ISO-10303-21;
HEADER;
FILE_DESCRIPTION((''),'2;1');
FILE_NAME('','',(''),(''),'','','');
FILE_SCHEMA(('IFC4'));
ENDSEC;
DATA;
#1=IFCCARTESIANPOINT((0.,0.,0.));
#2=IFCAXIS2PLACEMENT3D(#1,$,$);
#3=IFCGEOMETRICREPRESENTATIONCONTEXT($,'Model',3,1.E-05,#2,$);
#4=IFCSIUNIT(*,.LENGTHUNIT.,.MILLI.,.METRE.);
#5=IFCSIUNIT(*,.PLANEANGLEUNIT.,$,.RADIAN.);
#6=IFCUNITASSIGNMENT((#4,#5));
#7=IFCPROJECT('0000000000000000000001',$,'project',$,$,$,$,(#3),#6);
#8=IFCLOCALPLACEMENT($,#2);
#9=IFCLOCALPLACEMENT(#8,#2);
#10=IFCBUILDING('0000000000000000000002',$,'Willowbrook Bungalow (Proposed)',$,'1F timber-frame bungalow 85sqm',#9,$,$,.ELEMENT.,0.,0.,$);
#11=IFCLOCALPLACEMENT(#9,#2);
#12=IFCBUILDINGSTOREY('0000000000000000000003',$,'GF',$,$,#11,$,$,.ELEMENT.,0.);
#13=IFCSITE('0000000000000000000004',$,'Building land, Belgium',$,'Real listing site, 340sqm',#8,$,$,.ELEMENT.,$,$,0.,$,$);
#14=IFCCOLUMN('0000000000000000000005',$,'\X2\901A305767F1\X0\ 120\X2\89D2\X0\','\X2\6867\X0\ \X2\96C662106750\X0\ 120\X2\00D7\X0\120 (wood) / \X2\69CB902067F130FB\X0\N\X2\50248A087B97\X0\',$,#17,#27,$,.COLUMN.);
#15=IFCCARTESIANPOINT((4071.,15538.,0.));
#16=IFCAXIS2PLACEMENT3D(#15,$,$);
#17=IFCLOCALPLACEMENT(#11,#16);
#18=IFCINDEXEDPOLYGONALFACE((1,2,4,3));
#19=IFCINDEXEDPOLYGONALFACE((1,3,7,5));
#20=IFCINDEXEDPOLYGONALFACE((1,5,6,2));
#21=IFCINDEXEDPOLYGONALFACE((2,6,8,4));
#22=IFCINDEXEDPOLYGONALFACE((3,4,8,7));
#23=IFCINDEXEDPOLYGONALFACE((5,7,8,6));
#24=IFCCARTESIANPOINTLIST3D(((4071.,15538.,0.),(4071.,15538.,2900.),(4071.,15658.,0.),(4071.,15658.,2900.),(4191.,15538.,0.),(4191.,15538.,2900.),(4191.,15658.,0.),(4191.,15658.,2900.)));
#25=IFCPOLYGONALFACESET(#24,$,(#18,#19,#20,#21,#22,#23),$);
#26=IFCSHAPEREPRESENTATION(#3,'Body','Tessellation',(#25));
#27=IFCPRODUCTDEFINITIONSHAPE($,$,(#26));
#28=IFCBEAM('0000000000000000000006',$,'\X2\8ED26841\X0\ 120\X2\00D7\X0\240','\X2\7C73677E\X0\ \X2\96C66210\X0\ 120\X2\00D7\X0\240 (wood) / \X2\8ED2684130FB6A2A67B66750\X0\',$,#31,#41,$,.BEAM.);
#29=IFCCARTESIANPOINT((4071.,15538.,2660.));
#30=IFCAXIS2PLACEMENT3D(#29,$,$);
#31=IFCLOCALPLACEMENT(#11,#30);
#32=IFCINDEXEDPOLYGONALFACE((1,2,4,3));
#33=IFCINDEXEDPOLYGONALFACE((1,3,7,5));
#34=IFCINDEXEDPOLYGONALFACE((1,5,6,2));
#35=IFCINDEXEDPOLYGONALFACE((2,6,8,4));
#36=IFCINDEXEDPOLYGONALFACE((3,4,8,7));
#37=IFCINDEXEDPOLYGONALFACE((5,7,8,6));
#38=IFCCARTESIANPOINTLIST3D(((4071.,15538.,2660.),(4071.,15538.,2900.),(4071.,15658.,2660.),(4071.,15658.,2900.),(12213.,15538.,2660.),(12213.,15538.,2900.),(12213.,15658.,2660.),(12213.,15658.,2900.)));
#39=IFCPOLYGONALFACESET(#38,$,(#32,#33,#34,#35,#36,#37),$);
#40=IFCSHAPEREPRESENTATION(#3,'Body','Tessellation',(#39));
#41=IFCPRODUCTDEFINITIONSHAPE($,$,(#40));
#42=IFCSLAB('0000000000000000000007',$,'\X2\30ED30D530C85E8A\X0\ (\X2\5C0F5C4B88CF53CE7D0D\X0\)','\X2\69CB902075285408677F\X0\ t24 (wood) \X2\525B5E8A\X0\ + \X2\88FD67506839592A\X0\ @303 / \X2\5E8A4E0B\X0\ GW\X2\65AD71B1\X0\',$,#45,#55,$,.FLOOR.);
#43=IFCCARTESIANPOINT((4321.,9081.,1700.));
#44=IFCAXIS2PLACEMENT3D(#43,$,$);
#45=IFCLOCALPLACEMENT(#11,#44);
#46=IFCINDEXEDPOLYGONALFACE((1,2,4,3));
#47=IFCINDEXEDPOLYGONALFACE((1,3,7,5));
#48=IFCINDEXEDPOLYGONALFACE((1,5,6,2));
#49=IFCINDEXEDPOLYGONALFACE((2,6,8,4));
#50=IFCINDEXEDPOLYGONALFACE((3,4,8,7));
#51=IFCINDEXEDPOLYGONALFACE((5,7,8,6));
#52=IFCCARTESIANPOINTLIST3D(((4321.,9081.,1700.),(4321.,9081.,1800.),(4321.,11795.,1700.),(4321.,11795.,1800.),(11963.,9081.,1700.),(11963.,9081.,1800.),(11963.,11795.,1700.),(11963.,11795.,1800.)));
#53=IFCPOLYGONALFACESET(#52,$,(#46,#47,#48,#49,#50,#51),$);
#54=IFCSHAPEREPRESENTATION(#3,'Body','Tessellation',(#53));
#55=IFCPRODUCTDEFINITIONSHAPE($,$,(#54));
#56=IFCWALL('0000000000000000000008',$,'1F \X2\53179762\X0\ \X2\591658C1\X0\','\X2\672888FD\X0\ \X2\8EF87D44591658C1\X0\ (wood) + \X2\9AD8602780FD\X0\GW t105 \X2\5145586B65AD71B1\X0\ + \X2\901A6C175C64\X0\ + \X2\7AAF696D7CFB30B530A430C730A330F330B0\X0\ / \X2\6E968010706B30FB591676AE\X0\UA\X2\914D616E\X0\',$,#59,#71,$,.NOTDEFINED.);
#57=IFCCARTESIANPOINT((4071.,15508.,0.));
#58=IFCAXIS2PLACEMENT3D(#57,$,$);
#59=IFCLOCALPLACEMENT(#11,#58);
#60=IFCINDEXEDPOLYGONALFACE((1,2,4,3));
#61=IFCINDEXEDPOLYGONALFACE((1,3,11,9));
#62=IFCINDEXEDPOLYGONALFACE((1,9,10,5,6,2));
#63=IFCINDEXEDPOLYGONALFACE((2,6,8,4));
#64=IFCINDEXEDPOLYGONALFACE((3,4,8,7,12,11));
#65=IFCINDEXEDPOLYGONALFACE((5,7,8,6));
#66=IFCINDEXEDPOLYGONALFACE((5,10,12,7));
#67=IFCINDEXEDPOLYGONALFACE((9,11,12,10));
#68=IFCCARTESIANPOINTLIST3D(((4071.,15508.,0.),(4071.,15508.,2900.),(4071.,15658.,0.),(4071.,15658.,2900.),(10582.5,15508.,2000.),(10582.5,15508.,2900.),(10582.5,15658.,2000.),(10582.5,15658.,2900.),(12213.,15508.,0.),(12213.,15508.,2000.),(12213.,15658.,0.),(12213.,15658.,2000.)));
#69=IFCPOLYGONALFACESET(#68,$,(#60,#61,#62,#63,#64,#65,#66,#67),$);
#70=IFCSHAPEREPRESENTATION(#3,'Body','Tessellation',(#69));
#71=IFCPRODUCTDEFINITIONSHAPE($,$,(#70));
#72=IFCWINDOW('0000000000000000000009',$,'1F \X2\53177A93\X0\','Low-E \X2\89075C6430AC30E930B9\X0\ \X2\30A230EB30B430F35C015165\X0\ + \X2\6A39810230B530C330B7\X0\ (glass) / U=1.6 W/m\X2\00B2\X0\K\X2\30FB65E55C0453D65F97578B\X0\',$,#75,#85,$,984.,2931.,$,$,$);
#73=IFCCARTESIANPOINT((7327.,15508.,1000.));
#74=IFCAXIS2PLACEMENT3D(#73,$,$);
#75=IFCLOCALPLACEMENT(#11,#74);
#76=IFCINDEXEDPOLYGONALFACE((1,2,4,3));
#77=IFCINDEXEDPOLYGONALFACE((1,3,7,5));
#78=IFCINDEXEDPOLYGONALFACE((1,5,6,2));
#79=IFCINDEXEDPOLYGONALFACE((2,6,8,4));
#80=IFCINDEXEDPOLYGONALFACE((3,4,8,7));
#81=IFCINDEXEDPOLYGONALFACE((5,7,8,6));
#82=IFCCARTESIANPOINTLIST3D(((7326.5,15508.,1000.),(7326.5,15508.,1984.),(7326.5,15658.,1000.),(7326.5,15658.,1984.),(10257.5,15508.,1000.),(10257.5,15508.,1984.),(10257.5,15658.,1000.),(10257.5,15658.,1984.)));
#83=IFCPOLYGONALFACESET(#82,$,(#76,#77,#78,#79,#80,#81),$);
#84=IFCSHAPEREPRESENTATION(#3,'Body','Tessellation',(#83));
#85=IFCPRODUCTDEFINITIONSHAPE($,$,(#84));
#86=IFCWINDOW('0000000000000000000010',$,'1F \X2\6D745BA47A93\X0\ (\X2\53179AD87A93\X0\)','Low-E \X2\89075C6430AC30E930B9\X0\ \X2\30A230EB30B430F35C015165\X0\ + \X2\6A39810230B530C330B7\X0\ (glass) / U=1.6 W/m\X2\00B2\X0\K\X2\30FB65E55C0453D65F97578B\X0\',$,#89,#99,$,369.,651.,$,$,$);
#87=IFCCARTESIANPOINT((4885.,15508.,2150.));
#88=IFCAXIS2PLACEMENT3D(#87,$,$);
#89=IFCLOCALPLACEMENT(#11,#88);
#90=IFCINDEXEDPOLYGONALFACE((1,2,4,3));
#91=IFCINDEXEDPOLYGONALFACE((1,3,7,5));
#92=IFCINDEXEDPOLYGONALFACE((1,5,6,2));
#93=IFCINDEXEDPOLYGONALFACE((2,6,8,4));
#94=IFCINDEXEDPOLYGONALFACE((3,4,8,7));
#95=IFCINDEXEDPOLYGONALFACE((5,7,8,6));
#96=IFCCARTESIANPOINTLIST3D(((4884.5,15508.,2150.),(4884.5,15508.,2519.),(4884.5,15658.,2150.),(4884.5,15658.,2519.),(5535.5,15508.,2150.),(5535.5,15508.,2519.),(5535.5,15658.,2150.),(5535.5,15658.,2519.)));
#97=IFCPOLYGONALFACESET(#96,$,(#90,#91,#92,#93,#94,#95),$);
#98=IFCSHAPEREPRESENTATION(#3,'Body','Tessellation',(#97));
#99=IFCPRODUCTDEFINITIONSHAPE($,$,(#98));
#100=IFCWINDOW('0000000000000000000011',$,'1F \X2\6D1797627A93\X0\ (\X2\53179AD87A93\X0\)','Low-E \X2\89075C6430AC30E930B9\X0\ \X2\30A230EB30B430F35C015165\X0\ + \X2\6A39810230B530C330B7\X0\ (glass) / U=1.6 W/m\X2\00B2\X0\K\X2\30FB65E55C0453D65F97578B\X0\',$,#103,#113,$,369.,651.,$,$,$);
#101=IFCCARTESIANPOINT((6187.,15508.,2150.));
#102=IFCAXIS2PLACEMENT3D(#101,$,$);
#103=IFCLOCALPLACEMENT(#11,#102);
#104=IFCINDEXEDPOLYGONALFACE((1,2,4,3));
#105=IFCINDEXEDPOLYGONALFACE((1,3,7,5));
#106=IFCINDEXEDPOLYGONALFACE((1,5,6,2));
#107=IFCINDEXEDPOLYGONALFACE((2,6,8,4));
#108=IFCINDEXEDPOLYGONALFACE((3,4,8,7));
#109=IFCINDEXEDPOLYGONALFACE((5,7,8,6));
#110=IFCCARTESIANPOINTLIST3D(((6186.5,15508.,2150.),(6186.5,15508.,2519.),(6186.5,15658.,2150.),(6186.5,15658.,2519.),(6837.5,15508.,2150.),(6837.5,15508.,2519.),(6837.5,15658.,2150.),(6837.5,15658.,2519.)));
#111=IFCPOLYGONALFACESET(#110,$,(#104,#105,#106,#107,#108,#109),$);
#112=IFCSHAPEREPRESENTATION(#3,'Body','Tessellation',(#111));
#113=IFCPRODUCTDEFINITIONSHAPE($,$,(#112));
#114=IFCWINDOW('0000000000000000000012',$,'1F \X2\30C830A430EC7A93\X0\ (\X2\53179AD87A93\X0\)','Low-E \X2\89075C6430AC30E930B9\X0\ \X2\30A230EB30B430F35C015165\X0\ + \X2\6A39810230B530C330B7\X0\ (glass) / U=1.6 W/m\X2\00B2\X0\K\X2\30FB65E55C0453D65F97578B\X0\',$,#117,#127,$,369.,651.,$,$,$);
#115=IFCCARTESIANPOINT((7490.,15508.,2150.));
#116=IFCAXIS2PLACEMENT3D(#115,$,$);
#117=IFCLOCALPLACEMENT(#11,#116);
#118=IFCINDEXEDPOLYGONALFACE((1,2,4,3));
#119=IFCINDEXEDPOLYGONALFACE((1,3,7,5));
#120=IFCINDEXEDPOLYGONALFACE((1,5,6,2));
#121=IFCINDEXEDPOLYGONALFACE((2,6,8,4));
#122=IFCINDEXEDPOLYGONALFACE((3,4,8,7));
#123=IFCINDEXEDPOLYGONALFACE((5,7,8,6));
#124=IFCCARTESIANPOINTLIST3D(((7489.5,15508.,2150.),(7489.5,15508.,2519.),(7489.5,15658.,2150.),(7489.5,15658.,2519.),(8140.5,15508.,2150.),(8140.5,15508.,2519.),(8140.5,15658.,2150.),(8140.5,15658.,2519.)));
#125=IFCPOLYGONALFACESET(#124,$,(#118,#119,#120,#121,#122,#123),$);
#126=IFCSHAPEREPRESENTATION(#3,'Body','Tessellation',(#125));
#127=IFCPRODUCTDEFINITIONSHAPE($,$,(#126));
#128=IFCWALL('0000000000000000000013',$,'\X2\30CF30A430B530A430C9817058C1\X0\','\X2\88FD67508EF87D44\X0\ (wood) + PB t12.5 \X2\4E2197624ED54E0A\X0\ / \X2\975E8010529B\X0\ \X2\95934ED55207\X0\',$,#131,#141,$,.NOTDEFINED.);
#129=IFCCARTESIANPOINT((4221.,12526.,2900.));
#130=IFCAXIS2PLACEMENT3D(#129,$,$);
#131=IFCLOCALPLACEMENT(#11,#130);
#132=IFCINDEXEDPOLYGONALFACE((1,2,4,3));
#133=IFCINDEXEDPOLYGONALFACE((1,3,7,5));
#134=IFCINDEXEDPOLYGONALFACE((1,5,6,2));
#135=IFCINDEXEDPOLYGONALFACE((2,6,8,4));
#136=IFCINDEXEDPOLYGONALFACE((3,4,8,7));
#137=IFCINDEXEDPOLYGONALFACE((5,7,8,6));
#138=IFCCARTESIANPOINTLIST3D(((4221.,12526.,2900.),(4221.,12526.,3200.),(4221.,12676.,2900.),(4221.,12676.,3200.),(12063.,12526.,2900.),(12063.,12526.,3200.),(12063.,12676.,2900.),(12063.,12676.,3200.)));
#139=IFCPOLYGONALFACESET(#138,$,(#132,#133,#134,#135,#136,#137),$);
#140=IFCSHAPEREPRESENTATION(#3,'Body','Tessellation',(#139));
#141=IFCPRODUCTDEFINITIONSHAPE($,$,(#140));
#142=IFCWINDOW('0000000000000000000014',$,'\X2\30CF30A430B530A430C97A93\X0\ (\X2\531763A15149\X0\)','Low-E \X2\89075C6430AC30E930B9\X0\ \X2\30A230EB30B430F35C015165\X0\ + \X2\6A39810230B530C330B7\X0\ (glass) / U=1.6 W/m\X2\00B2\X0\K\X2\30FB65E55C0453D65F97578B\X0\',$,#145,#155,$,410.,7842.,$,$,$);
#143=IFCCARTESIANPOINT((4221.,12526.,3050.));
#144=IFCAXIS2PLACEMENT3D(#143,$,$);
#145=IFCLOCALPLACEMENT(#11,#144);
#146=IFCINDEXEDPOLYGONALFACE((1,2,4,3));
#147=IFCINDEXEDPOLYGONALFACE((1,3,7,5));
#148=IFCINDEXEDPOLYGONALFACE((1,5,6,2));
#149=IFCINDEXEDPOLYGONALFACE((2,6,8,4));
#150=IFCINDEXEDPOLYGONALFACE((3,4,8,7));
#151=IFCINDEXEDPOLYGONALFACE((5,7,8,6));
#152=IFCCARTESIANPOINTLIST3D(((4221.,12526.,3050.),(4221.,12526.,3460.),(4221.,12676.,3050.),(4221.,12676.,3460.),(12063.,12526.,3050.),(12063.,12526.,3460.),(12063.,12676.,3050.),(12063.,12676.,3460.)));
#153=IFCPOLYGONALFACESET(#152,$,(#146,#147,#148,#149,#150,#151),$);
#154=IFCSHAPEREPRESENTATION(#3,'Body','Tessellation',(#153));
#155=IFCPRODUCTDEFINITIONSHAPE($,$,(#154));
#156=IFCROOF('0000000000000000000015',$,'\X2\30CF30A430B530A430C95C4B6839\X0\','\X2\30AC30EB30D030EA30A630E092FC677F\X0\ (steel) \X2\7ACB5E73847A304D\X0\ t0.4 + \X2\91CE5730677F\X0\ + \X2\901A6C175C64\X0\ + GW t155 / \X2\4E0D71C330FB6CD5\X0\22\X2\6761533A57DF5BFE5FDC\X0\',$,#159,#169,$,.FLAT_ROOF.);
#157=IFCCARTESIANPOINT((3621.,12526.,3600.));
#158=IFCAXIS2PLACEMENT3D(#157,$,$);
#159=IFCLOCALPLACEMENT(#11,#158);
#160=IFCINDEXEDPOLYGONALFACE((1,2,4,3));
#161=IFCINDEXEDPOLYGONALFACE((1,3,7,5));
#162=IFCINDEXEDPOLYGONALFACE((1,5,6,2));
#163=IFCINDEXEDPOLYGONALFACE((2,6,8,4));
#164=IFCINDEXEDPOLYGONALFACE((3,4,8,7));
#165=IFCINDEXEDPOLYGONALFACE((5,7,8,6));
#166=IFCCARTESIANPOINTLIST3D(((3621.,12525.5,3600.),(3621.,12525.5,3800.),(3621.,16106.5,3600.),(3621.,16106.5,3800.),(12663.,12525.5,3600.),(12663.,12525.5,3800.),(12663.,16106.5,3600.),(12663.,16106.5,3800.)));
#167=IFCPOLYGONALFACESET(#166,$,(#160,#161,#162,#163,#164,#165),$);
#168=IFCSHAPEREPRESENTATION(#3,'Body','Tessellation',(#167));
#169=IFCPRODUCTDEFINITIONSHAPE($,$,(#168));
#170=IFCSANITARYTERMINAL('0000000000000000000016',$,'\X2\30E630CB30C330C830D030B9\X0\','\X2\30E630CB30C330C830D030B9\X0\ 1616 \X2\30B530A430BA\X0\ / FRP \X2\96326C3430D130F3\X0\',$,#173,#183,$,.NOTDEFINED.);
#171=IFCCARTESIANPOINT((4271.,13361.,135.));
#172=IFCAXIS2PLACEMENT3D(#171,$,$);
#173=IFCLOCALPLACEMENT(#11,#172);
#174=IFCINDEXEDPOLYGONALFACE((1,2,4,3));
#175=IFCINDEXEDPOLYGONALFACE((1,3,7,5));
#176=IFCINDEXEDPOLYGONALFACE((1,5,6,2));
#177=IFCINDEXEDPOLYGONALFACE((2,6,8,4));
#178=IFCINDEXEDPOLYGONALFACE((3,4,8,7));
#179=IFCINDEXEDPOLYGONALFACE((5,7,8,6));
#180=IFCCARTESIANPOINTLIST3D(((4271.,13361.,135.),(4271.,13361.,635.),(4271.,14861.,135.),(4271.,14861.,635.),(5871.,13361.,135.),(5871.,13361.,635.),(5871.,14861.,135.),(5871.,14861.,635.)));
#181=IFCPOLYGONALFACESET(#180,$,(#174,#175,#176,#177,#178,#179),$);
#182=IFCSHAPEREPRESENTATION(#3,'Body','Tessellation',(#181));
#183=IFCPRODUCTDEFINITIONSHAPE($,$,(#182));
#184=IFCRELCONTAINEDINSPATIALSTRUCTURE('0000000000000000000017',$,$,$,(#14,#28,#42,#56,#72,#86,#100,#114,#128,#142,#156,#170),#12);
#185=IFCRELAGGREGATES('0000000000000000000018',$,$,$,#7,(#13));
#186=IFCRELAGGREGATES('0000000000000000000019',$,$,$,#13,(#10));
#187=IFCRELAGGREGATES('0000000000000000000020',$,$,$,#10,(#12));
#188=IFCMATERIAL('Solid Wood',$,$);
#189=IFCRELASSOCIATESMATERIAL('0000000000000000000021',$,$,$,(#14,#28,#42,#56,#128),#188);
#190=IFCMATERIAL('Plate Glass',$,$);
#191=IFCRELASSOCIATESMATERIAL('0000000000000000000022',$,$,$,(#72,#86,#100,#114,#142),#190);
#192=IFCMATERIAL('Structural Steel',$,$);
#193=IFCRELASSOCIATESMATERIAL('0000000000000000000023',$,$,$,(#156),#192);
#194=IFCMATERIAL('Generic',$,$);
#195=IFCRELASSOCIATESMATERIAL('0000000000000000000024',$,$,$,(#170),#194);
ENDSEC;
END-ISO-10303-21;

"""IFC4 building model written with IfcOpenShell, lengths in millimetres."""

from ifc_helpers import new_model, si_unit, frame, frame_2d, origin, place, context, project, spatial, rectangle, extrude, material, element, fill, save


model = new_model("IFC4")

# Units and contexts
model_context = context("Model", 3, precision=1e-05, world=origin())
ifc_project = project(units=[si_unit("LENGTHUNIT", "METRE", prefix="MILLI"), si_unit("PLANEANGLEUNIT", "RADIAN")], contexts=[model_context])

# Site, building, storey
site_placement = place(None, origin())
site = spatial("IfcSite", under=ifc_project, at=site_placement, Name="Building land, Belgium", ObjectType="Real listing site, 340sqm", CompositionType="ELEMENT", RefElevation=0.0)
building_placement = place(site_placement, origin())
building = spatial("IfcBuilding", under=site, at=building_placement, Name="Willowbrook Bungalow (Proposed)", ObjectType="1F timber-frame bungalow 85sqm", CompositionType="ELEMENT", ElevationOfRefHeight=0.0, ElevationOfTerrain=0.0)
storey_placement = place(building_placement, origin())
storey = spatial("IfcBuildingStorey", under=building, at=storey_placement, Name="GF", CompositionType="ELEMENT", Elevation=0.0)

# Column
ifc_material_1 = material(Name="Solid Wood")
column_1_placement = place(storey_placement, frame((4071.0, 15538.0, 0.0)))
element("IfcColumn", 1, at=column_1_placement, inside=storey, material=ifc_material_1, Name="通し柱 120角", Description="桧 集成材 120×120 (wood) / 構造柱・N値計算", PredefinedType="COLUMN", context=model_context, shape_type="SweptSolid", body=[
    extrude(rectangle(XDim=120.0, YDim=120.0, at=frame_2d((60.0, 60.0))), frame((4071.0, 15538.0, 0.0)), (0.0, 0.0, 1.0), 2900.0),
])

# Beam
beam_1_placement = place(storey_placement, frame((4071.0, 15538.0, 2660.0)))
element("IfcBeam", 2, at=beam_1_placement, inside=storey, material=ifc_material_1, Name="軒桁 120×240", Description="米松 集成 120×240 (wood) / 軒桁・横架材", PredefinedType="BEAM", context=model_context, shape_type="SweptSolid", body=[
    extrude(rectangle(XDim=8142.0, YDim=120.0, at=frame_2d((4071.0, 60.0))), frame((4071.0, 15538.0, 2660.0)), (0.0, 0.0, 1.0), 240.0),
])

# Slab
slab_placement = place(storey_placement, frame((4321.0, 9081.0, 1700.0)))
element("IfcSlab", 3, at=slab_placement, inside=storey, material=ifc_material_1, Name="ロフト床 (小屋裏収納)", Description="構造用合板 t24 (wood) 剛床 + 製材根太 @303 / 床下 GW断熱", PredefinedType="FLOOR", context=model_context, shape_type="SweptSolid", body=[
    extrude(rectangle(XDim=7642.0, YDim=2714.0, at=frame_2d((3821.0, 1357.0))), frame((4321.0, 9081.0, 1700.0)), (0.0, 0.0, 1.0), 100.0),
])

# Wall, openings, windows
wall_1_placement = place(storey_placement, frame((4071.0, 15508.0, 0.0)))
wall_1 = element("IfcWall", 4, at=wall_1_placement, inside=storey, material=ifc_material_1, Name="1F 北面 外壁", Description="木製 軸組外壁 (wood) + 高性能GW t105 充填断熱 + 通気層 + 窯業系サイディング / 準耐火・外皮UA配慮", PredefinedType="NOTDEFINED", context=model_context, shape_type="SweptSolid", body=[
    extrude(rectangle(XDim=8142.0, YDim=150.0, at=frame_2d((4071.0, 75.0))), frame((4071.0, 15508.0, 0.0)), (0.0, 0.0, 1.0), 2900.0),
])
opening_1_placement = place(storey_placement, frame((7327.0, 15508.0, 1000.0)))
opening_1 = element("IfcOpeningElement", 5, at=opening_1_placement, cuts=wall_1, PredefinedType="NOTDEFINED", context=model_context, shape_type="SweptSolid", body=[
    extrude(rectangle(XDim=2931.0, YDim=150.0, at=frame_2d((1465.0, 75.0))), frame((7327.0, 15508.0, 1000.0)), (0.0, 0.0, 1.0), 984.0),
])
opening_2_placement = place(storey_placement, frame((4885.0, 15508.0, 2150.0)))
opening_2 = element("IfcOpeningElement", 6, at=opening_2_placement, cuts=wall_1, PredefinedType="NOTDEFINED", context=model_context, shape_type="SweptSolid", body=[
    extrude(rectangle(XDim=651.0, YDim=150.0, at=frame_2d((325.0, 75.0))), frame((4885.0, 15508.0, 2150.0)), (0.0, 0.0, 1.0), 369.0),
])
opening_3_placement = place(storey_placement, frame((6187.0, 15508.0, 2150.0)))
opening_3 = element("IfcOpeningElement", 7, at=opening_3_placement, cuts=wall_1, PredefinedType="NOTDEFINED", context=model_context, shape_type="SweptSolid", body=[
    extrude(rectangle(XDim=651.0, YDim=150.0, at=frame_2d((325.0, 75.0))), frame((6187.0, 15508.0, 2150.0)), (0.0, 0.0, 1.0), 369.0),
])
opening_4_placement = place(storey_placement, frame((7490.0, 15508.0, 2150.0)))
opening_4 = element("IfcOpeningElement", 8, at=opening_4_placement, cuts=wall_1, PredefinedType="NOTDEFINED", context=model_context, shape_type="SweptSolid", body=[
    extrude(rectangle(XDim=651.0, YDim=150.0, at=frame_2d((325.0, 75.0))), frame((7490.0, 15508.0, 2150.0)), (0.0, 0.0, 1.0), 369.0),
])
ifc_material_2 = material(Name="Plate Glass")
window_1_placement = place(storey_placement, frame((7327.0, 15508.0, 1000.0)))
window_1 = element("IfcWindow", 9, at=window_1_placement, inside=storey, material=ifc_material_2, Name="1F 北窓", Description="Low-E 複層ガラス アルゴン封入 + 樹脂サッシ (glass) / U=1.6 W/m²K・日射取得型", OverallHeight=984.0, OverallWidth=2931.0, context=model_context, shape_type="SweptSolid", body=[
    extrude(rectangle(XDim=2931.0, YDim=150.0, at=frame_2d((1465.0, 75.0))), frame((7327.0, 15508.0, 1000.0)), (0.0, 0.0, 1.0), 984.0),
])
fill(opening_1, window_1)
window_2_placement = place(storey_placement, frame((4885.0, 15508.0, 2150.0)))
window_2 = element("IfcWindow", 10, at=window_2_placement, inside=storey, material=ifc_material_2, Name="1F 浴室窓 (北高窓)", Description="Low-E 複層ガラス アルゴン封入 + 樹脂サッシ (glass) / U=1.6 W/m²K・日射取得型", OverallHeight=369.0, OverallWidth=651.0, context=model_context, shape_type="SweptSolid", body=[
    extrude(rectangle(XDim=651.0, YDim=150.0, at=frame_2d((325.0, 75.0))), frame((4885.0, 15508.0, 2150.0)), (0.0, 0.0, 1.0), 369.0),
])
fill(opening_2, window_2)
window_3_placement = place(storey_placement, frame((6187.0, 15508.0, 2150.0)))
window_3 = element("IfcWindow", 11, at=window_3_placement, inside=storey, material=ifc_material_2, Name="1F 洗面窓 (北高窓)", Description="Low-E 複層ガラス アルゴン封入 + 樹脂サッシ (glass) / U=1.6 W/m²K・日射取得型", OverallHeight=369.0, OverallWidth=651.0, context=model_context, shape_type="SweptSolid", body=[
    extrude(rectangle(XDim=651.0, YDim=150.0, at=frame_2d((325.0, 75.0))), frame((6187.0, 15508.0, 2150.0)), (0.0, 0.0, 1.0), 369.0),
])
fill(opening_3, window_3)
window_4_placement = place(storey_placement, frame((7490.0, 15508.0, 2150.0)))
window_4 = element("IfcWindow", 12, at=window_4_placement, inside=storey, material=ifc_material_2, Name="1F トイレ窓 (北高窓)", Description="Low-E 複層ガラス アルゴン封入 + 樹脂サッシ (glass) / U=1.6 W/m²K・日射取得型", OverallHeight=369.0, OverallWidth=651.0, context=model_context, shape_type="SweptSolid", body=[
    extrude(rectangle(XDim=651.0, YDim=150.0, at=frame_2d((325.0, 75.0))), frame((7490.0, 15508.0, 2150.0)), (0.0, 0.0, 1.0), 369.0),
])
fill(opening_4, window_4)

# Wall, opening, window
wall_2_placement = place(storey_placement, frame((4221.0, 12526.0, 2900.0)))
wall_2 = element("IfcWall", 13, at=wall_2_placement, inside=storey, material=ifc_material_1, Name="ハイサイド腰壁", Description="製材軸組 (wood) + PB t12.5 両面仕上 / 非耐力 間仕切", PredefinedType="NOTDEFINED", context=model_context, shape_type="SweptSolid", body=[
    extrude(rectangle(XDim=7842.0, YDim=150.0, at=frame_2d((3921.0, 75.0))), frame((4221.0, 12526.0, 2900.0)), (0.0, 0.0, 1.0), 700.0),
])
opening_5_placement = place(storey_placement, frame((4221.0, 12526.0, 3050.0)))
opening_5 = element("IfcOpeningElement", 14, at=opening_5_placement, cuts=wall_2, PredefinedType="NOTDEFINED", context=model_context, shape_type="SweptSolid", body=[
    extrude(rectangle(XDim=7842.0, YDim=150.0, at=frame_2d((3921.0, 75.0))), frame((4221.0, 12526.0, 3050.0)), (0.0, 0.0, 1.0), 410.0),
])
window_5_placement = place(storey_placement, frame((4221.0, 12526.0, 3050.0)))
window_5 = element("IfcWindow", 15, at=window_5_placement, inside=storey, material=ifc_material_2, Name="ハイサイド窓 (北採光)", Description="Low-E 複層ガラス アルゴン封入 + 樹脂サッシ (glass) / U=1.6 W/m²K・日射取得型", OverallHeight=410.0, OverallWidth=7842.0, context=model_context, shape_type="SweptSolid", body=[
    extrude(rectangle(XDim=7842.0, YDim=150.0, at=frame_2d((3921.0, 75.0))), frame((4221.0, 12526.0, 3050.0)), (0.0, 0.0, 1.0), 410.0),
])
fill(opening_5, window_5)

# Roof
ifc_material_3 = material(Name="Structural Steel")
roof_placement = place(storey_placement, frame((3621.0, 12526.0, 3600.0)))
element("IfcRoof", 16, at=roof_placement, inside=storey, material=ifc_material_3, Name="ハイサイド屋根", Description="ガルバリウム鋼板 (steel) 立平葺き t0.4 + 野地板 + 通気層 + GW t155 / 不燃・法22条区域対応", PredefinedType="FLAT_ROOF", context=model_context, shape_type="SweptSolid", body=[
    extrude(rectangle(XDim=9042.0, YDim=3581.0, at=frame_2d((4521.0, 1790.0))), frame((3621.0, 12526.0, 3600.0)), (0.0, 0.0, 1.0), 200.0),
])

# Sanitary terminal
ifc_material_4 = material(Name="Generic")
sanitary_terminal_placement = place(storey_placement, frame((4271.0, 13361.0, 135.0)))
element("IfcSanitaryTerminal", 17, at=sanitary_terminal_placement, inside=storey, material=ifc_material_4, Name="ユニットバス", Description="ユニットバス 1616 サイズ / FRP 防水パン", PredefinedType="NOTDEFINED", context=model_context, shape_type="SweptSolid", body=[
    extrude(rectangle(XDim=1600.0, YDim=1500.0, at=frame_2d((800.0, 750.0))), frame((4271.0, 13361.0, 135.0)), (0.0, 0.0, 1.0), 500.0),
])

save(model, "model.ifc")
